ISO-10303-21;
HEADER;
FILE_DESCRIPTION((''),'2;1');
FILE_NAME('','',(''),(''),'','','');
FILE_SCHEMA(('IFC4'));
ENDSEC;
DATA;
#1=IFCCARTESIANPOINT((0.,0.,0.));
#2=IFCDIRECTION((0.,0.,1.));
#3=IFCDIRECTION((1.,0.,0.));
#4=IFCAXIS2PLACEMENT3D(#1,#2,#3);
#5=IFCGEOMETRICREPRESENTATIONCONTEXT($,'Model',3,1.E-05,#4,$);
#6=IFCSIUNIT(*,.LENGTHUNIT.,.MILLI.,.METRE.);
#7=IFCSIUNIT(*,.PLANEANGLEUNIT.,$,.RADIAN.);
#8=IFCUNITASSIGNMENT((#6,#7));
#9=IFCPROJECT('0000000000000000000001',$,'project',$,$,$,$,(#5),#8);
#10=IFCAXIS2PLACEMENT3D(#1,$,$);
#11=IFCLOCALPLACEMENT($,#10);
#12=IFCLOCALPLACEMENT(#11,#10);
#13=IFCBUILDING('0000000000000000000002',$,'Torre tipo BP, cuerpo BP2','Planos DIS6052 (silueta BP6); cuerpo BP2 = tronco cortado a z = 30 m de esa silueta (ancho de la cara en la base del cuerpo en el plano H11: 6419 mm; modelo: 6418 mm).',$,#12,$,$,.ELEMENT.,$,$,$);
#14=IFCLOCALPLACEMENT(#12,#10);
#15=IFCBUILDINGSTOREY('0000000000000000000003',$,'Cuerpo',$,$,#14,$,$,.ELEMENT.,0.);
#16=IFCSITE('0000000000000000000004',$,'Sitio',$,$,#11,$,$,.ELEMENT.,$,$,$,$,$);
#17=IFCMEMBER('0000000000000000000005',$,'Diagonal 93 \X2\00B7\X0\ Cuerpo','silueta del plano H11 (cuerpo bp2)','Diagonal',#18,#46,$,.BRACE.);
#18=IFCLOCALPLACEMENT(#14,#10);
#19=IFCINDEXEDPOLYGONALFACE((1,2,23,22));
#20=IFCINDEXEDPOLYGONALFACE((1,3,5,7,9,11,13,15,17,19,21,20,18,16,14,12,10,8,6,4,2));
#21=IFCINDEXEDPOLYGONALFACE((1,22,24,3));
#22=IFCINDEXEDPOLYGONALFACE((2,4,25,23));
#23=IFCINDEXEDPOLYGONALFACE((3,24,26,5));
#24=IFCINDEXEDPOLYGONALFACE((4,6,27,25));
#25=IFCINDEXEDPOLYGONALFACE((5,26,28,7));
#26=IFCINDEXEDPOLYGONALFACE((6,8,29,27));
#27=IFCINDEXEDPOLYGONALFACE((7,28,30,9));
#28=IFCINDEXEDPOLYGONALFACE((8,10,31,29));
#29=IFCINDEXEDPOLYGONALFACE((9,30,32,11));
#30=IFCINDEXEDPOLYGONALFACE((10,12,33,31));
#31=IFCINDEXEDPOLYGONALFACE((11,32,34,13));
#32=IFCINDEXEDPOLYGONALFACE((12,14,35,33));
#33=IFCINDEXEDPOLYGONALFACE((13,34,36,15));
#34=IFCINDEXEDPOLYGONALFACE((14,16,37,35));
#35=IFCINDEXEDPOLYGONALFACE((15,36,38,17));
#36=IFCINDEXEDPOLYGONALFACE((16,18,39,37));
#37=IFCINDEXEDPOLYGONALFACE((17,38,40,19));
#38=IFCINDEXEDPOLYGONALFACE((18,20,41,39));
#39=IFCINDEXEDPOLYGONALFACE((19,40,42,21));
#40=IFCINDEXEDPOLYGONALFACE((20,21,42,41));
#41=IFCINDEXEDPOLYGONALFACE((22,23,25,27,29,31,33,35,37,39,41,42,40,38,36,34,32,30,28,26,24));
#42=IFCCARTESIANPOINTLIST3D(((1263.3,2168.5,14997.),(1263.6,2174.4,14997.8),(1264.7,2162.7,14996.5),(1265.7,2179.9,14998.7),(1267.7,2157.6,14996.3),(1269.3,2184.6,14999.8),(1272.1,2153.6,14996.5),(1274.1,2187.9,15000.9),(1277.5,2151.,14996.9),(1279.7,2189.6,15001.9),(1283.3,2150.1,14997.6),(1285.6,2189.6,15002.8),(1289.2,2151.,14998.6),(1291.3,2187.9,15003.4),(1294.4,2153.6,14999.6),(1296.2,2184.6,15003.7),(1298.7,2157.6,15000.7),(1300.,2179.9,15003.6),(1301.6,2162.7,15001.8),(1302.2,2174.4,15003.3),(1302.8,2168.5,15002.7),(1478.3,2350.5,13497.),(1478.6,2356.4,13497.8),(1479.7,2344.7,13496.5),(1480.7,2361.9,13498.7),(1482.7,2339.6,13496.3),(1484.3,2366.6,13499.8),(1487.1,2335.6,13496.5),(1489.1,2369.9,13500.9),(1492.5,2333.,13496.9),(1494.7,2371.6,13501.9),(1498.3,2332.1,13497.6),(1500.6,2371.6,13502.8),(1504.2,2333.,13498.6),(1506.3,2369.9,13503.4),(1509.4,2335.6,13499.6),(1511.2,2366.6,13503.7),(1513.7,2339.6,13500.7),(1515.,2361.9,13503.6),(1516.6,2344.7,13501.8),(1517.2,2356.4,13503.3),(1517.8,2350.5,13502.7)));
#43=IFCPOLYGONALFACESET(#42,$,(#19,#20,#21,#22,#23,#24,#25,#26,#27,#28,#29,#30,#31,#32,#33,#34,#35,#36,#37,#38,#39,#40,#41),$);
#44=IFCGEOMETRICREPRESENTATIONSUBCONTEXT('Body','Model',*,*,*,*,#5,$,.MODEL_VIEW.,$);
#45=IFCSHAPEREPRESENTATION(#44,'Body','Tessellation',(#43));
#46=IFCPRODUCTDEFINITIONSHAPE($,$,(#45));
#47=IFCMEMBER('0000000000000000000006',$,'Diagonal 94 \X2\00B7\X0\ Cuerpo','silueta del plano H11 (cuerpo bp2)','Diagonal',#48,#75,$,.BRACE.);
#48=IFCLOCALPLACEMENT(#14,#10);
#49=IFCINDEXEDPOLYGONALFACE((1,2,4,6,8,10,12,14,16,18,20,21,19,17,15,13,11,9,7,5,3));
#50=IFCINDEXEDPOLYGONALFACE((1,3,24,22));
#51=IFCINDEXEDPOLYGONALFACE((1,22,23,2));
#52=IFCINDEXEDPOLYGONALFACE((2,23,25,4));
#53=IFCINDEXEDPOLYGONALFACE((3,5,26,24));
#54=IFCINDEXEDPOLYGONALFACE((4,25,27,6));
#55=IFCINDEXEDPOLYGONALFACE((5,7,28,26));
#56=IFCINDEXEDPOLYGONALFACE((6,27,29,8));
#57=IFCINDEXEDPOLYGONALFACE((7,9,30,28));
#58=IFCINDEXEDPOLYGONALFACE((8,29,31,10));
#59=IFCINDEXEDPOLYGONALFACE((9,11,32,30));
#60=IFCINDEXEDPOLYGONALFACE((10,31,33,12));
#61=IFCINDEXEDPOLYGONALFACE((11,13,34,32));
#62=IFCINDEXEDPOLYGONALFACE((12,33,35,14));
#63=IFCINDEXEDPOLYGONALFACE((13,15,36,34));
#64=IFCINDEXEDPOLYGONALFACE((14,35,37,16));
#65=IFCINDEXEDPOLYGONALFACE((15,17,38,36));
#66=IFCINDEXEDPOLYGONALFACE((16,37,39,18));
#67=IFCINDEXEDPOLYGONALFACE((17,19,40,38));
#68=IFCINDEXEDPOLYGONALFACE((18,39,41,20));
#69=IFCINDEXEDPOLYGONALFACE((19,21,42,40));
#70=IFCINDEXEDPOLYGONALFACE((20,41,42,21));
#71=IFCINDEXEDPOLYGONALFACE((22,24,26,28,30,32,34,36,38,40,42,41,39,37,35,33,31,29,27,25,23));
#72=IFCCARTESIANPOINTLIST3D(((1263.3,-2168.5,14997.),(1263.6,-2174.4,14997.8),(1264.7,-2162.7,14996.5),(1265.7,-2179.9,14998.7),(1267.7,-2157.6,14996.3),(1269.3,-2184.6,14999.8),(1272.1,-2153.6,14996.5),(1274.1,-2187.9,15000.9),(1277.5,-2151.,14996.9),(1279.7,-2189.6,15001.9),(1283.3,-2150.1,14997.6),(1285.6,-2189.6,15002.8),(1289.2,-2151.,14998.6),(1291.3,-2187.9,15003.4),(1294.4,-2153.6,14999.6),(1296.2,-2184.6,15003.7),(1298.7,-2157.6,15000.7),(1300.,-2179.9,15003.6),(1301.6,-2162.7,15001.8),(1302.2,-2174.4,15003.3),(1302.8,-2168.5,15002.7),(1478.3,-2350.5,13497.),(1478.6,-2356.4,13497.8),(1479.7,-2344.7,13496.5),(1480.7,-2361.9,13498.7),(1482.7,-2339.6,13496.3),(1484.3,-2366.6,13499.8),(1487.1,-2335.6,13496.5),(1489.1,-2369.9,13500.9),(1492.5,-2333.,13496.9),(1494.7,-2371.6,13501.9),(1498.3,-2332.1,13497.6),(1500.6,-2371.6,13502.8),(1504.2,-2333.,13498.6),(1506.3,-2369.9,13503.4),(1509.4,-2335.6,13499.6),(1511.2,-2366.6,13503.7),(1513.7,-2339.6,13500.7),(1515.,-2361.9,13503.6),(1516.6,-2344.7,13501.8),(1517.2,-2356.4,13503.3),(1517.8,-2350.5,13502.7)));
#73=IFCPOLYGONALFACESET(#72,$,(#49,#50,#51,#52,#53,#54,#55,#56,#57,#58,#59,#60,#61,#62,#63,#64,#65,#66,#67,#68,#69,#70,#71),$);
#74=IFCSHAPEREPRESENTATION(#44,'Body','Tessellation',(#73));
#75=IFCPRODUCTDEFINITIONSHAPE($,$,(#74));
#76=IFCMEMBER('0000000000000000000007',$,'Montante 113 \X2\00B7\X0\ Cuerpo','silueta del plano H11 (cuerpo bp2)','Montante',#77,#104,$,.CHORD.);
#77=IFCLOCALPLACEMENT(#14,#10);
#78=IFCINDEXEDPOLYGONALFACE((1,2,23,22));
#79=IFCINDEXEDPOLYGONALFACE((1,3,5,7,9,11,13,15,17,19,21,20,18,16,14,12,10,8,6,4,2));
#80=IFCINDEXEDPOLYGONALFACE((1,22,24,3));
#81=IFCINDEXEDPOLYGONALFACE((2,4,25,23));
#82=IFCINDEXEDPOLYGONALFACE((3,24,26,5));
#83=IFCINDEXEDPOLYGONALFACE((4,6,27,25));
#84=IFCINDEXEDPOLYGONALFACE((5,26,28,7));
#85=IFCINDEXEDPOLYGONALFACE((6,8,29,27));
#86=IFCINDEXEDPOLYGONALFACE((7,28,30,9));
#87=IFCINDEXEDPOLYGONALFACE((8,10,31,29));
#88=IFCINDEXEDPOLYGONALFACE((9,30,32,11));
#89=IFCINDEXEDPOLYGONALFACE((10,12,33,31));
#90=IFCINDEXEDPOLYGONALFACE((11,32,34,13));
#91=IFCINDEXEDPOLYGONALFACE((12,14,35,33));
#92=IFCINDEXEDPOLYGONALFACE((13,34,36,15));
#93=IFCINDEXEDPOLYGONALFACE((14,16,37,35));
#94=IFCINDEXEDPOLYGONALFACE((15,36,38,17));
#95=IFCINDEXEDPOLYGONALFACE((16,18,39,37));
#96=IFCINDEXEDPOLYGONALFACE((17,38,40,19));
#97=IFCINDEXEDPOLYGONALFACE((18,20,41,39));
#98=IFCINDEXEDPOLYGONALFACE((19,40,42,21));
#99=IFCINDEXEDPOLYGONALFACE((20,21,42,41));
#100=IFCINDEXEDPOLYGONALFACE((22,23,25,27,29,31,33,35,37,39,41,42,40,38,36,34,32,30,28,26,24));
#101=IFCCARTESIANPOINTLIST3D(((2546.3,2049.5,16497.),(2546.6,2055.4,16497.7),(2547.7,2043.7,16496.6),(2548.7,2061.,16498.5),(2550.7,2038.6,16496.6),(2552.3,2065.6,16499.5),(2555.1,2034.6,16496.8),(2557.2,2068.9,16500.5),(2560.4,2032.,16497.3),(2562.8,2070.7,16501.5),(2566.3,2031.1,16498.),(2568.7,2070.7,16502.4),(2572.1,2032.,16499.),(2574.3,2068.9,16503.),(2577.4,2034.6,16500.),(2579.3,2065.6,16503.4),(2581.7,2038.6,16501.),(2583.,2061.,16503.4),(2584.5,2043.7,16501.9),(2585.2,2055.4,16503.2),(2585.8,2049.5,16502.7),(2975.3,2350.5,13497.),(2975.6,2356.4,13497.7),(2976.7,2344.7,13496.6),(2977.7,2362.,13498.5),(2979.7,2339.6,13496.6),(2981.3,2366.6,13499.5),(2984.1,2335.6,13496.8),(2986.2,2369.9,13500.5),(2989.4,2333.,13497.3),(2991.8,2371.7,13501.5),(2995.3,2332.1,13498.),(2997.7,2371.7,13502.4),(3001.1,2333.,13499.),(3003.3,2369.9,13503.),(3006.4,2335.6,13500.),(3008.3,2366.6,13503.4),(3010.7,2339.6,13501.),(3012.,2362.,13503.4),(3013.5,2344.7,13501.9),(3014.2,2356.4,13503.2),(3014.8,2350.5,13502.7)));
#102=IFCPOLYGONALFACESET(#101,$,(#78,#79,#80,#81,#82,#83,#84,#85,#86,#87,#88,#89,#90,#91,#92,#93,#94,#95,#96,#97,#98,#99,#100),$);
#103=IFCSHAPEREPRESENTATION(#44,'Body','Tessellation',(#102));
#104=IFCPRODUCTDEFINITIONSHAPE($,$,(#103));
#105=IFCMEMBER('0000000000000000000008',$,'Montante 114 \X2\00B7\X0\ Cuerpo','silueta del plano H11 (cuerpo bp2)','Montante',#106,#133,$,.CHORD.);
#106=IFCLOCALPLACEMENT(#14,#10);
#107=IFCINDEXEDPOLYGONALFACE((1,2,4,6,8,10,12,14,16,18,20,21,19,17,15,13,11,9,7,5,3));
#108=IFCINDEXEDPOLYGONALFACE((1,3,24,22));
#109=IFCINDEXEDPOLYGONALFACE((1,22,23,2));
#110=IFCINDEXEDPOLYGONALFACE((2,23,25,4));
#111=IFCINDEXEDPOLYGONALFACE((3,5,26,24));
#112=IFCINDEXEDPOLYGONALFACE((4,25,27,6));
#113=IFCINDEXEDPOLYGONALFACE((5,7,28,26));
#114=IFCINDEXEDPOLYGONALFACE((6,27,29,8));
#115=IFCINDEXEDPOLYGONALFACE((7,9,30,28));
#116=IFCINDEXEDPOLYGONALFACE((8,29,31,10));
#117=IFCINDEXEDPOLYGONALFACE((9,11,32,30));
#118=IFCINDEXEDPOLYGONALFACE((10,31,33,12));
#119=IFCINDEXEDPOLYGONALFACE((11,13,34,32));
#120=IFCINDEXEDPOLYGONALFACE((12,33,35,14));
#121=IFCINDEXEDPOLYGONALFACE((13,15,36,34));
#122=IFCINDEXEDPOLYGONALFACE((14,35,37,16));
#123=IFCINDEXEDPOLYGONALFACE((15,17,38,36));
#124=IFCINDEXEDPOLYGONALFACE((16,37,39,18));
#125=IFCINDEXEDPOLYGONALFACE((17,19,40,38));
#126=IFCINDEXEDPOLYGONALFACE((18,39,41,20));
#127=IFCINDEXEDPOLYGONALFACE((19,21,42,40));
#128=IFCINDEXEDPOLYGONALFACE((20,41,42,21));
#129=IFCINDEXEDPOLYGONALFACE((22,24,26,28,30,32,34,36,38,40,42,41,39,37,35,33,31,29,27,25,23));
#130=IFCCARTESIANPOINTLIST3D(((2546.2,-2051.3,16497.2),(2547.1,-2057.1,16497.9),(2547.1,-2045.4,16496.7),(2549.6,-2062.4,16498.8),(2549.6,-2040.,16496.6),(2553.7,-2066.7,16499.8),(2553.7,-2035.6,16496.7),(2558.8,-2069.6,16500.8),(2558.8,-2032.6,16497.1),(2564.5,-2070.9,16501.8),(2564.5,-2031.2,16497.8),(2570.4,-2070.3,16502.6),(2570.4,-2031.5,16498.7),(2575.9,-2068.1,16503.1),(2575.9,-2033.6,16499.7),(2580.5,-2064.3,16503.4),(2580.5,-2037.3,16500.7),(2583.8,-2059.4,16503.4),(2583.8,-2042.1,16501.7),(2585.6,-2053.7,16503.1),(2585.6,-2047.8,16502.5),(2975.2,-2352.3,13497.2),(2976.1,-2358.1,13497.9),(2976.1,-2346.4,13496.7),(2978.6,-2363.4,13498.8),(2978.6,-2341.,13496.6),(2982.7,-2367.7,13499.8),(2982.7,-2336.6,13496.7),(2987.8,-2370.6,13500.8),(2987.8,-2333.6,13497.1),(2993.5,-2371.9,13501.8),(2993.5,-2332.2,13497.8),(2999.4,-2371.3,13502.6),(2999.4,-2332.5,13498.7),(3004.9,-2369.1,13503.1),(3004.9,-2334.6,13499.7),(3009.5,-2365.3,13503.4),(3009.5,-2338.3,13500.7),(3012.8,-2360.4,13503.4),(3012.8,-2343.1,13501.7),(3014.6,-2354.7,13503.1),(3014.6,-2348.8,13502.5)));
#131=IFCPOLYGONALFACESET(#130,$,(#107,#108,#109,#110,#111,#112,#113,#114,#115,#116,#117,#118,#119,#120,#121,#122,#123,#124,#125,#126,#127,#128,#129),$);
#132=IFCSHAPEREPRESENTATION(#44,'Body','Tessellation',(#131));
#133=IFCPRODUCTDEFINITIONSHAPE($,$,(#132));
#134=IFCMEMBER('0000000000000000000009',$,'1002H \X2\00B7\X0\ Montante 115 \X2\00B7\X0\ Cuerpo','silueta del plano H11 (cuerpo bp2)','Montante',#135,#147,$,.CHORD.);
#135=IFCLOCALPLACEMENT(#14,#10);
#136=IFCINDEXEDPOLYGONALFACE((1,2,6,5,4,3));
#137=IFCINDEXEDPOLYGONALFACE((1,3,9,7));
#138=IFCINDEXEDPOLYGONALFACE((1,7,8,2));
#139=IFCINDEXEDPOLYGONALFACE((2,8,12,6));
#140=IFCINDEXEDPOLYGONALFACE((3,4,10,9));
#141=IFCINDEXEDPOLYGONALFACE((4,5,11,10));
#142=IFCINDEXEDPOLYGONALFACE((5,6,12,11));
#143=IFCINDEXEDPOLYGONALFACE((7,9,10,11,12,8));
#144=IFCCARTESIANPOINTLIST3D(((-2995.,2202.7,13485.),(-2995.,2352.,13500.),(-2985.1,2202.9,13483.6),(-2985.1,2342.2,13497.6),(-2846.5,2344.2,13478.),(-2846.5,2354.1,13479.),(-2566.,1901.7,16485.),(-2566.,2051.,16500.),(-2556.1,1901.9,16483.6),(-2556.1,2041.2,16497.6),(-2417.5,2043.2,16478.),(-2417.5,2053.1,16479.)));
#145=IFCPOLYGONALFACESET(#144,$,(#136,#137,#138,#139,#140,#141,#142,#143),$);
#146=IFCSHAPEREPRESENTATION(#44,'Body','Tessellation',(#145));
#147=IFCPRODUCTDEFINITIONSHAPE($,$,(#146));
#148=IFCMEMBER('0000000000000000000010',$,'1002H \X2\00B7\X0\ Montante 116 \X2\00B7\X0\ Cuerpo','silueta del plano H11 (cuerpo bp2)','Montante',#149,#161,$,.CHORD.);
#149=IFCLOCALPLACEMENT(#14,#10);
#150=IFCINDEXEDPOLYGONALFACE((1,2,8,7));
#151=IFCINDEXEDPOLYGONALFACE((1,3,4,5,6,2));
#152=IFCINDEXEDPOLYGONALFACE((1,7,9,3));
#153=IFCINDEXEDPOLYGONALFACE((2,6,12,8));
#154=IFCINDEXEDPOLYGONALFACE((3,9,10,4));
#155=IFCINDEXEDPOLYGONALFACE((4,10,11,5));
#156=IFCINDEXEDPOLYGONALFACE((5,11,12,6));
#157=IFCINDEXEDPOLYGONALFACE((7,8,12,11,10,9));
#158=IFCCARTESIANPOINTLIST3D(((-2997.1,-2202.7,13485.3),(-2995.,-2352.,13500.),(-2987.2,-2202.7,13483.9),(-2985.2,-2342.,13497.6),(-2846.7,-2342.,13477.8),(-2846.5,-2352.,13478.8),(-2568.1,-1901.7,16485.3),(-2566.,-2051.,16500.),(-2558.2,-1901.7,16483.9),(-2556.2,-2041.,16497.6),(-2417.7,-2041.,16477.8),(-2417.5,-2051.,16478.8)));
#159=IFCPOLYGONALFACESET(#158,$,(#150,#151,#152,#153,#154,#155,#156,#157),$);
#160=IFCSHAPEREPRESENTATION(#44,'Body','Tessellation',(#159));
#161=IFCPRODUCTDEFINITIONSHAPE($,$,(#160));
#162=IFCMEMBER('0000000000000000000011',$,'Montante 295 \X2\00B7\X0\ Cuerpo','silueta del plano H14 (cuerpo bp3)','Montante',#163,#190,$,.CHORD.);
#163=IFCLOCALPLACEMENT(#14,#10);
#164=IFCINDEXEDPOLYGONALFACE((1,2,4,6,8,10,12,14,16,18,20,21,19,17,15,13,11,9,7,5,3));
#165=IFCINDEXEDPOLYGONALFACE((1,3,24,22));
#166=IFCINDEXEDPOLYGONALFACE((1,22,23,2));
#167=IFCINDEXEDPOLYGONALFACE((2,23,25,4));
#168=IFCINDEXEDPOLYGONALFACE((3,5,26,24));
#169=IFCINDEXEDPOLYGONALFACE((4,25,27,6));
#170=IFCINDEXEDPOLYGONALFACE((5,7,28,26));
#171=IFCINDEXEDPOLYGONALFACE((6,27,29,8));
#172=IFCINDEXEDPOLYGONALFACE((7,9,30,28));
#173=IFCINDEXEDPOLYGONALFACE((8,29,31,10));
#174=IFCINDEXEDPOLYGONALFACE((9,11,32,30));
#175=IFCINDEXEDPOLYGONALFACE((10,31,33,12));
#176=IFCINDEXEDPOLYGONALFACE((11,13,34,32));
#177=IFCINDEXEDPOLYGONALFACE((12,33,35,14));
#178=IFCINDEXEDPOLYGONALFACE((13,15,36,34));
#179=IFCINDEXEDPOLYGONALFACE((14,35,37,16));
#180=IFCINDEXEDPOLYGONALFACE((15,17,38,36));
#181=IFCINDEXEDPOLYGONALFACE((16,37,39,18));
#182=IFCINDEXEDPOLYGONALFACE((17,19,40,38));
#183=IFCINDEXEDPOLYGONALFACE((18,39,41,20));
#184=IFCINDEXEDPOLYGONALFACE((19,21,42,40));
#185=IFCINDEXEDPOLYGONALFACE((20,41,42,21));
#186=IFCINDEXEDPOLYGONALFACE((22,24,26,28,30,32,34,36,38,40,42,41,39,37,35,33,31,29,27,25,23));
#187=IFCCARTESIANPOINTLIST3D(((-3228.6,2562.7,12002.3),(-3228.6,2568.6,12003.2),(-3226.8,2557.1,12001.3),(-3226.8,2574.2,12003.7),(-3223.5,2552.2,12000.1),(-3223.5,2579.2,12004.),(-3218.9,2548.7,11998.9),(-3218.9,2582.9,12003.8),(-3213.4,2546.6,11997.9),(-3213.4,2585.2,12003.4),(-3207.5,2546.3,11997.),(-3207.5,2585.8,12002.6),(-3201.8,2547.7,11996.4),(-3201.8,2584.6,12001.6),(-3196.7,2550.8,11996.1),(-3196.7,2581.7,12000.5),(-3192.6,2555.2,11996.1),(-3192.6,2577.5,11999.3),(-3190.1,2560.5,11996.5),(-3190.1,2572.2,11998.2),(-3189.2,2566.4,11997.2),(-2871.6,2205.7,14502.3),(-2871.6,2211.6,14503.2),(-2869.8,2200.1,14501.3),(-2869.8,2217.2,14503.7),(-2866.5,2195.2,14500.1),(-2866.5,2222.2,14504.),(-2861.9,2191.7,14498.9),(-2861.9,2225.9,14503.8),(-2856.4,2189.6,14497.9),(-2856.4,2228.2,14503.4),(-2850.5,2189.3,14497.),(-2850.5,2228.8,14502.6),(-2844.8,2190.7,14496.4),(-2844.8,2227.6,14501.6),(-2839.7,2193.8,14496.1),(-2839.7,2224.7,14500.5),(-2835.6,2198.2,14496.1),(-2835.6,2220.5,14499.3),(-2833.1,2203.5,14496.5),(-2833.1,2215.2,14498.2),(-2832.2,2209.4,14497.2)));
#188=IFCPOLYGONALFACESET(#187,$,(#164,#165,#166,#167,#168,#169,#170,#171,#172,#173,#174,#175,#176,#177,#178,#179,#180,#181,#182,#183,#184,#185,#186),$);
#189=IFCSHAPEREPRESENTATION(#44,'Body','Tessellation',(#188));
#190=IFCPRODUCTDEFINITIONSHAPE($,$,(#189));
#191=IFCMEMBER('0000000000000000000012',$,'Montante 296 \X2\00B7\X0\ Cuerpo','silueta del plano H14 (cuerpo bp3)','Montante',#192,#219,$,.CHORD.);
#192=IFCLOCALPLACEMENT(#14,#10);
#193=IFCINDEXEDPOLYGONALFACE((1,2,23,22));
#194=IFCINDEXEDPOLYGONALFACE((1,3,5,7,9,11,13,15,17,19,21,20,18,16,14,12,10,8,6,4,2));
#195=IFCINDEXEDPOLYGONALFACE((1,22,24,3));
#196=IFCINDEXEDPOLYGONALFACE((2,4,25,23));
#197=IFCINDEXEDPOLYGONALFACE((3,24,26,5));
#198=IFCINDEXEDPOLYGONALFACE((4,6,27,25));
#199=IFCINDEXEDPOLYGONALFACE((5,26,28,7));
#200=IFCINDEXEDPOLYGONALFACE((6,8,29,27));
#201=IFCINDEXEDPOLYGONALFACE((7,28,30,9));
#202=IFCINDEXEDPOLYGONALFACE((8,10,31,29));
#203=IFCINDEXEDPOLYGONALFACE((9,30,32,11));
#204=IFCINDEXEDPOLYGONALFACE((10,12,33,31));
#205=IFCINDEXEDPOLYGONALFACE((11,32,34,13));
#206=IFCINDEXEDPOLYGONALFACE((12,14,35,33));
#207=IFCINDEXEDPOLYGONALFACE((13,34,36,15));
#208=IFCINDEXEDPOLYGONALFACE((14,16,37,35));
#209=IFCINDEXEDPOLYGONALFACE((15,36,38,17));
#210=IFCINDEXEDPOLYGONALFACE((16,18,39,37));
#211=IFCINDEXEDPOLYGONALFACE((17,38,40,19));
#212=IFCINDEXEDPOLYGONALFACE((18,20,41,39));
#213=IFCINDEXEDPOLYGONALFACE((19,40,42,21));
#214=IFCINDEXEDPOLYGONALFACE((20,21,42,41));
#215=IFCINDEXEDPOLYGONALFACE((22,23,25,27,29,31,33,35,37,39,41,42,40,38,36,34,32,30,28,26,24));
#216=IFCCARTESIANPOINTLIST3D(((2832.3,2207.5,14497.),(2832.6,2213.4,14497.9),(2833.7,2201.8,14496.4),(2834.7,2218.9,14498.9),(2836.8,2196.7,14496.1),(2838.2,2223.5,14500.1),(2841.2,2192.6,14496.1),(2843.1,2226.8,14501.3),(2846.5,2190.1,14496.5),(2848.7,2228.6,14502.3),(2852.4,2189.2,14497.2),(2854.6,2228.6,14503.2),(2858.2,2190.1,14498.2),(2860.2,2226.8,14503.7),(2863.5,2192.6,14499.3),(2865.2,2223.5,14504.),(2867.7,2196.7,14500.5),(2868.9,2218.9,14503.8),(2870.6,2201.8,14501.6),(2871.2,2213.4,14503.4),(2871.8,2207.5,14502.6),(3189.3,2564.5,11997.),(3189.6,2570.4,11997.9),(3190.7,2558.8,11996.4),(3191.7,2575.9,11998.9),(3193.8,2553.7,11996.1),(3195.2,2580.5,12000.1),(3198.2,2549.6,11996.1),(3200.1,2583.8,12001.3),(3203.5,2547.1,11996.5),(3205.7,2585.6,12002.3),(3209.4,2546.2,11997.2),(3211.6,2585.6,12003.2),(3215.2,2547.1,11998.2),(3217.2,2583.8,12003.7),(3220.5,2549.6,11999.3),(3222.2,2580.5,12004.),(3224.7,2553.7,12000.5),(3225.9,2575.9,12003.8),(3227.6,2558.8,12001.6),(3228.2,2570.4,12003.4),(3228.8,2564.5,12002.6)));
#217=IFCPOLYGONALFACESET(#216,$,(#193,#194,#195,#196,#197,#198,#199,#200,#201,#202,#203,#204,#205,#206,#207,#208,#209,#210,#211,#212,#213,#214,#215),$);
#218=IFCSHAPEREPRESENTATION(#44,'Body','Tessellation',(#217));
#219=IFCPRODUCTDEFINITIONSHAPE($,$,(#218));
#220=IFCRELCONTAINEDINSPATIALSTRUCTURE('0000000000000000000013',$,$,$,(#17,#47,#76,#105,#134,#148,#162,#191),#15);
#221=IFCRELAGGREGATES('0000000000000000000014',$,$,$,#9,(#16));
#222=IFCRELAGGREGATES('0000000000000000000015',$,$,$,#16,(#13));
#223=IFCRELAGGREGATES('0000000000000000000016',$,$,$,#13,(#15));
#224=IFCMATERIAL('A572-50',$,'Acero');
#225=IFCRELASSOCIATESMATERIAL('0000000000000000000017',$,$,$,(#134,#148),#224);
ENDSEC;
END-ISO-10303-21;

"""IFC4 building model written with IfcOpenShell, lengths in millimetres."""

from ifc_helpers import new_model, si_unit, frame, frame_2d, origin, origin_with_axes, place, context, subcontext, project, spatial, circle, l_section, extrude, material, element, save


model = new_model("IFC4")

# Units and contexts
model_context = context("Model", 3, precision=1e-05, world=origin_with_axes())
body_context = subcontext(model_context, "Body", "Model", "MODEL_VIEW")
ifc_project = project(units=[si_unit("LENGTHUNIT", "METRE", prefix="MILLI"), si_unit("PLANEANGLEUNIT", "RADIAN")], contexts=[model_context])

# Site, building, storey
site_placement = place(None, origin())
site = spatial("IfcSite", under=ifc_project, at=site_placement, Name="Sitio", CompositionType="ELEMENT")
building_placement = place(site_placement, origin())
building = spatial("IfcBuilding", under=site, at=building_placement, Name="Torre tipo BP, cuerpo BP2", Description="Planos DIS6052 (silueta BP6); cuerpo BP2 = tronco cortado a z = 30 m de esa silueta (ancho de la cara en la base del cuerpo en el plano H11: 6419 mm; modelo: 6418 mm).", CompositionType="ELEMENT")
storey_placement = place(building_placement, origin())
storey = spatial("IfcBuildingStorey", under=building, at=storey_placement, Name="Cuerpo", CompositionType="ELEMENT", Elevation=0.0)

# Members
for number, where, z_axis, x_axis, name in (
    (1, (1283.0, 2170.0, 15000.0), (0.140871, 0.119249, -0.98282), (0.016919, -0.992864, -0.118042), "Diagonal 93 · Cuerpo"),
    (2, (1283.0, -2170.0, 15000.0), (0.140871, -0.119249, -0.98282), (0.016919, 0.992864, -0.118042), "Diagonal 94 · Cuerpo"),
):
    element("IfcMember", number, at=place(storey_placement, frame(where, z_axis=z_axis, x_axis=x_axis)), inside=storey, Name=name, Description="silueta del plano H11 (cuerpo bp2)", ObjectType="Diagonal", PredefinedType="BRACE", context=body_context, shape_type="SweptSolid", body=[
        extrude(circle(Radius=20.0), None, (0.0, 0.0, 1.0), 1526.2),
    ])
for number, where, z_axis, x_axis, name in (
    (3, (2566.0, 2051.0, 16500.0), (0.140867, 0.098837, -0.985083), (0.013991, -0.995104, -0.097841), "Montante 113 · Cuerpo"),
    (4, (2566.0, -2051.0, 16500.0), (0.140867, -0.098837, -0.985083), (-0.990029, -0.014063, -0.140163), "Montante 114 · Cuerpo"),
):
    element("IfcMember", number, at=place(storey_placement, frame(where, z_axis=z_axis, x_axis=x_axis)), inside=storey, Name=name, Description="silueta del plano H11 (cuerpo bp2)", ObjectType="Montante", PredefinedType="CHORD", context=body_context, shape_type="SweptSolid", body=[
        extrude(circle(Radius=20.0), None, (0.0, 0.0, 1.0), 3045.4),
    ])
ifc_material = material(Name="A572-50", Category="Acero")
for number, where, z_axis, x_axis, name in (
    (5, (-2566.0, 2051.0, 16500.0), (-0.140867, 0.098837, -0.985083), (0.990029, 0.014063, -0.140163), "1002H · Montante 115 · Cuerpo"),
    (6, (-2566.0, -2051.0, 16500.0), (-0.140867, -0.098837, -0.985083), (-0.013991, 0.995104, -0.097841), "1002H · Montante 116 · Cuerpo"),
):
    element("IfcMember", number, at=place(storey_placement, frame(where, z_axis=z_axis, x_axis=x_axis)), inside=storey, material=ifc_material, Name=name, Description="silueta del plano H11 (cuerpo bp2)", ObjectType="Montante", PredefinedType="CHORD", context=body_context, shape_type="SweptSolid", body=[
        extrude(l_section(Depth=150.0, Width=150.0, Thickness=10.0, at=frame_2d((75.0, 75.0))), None, (0.0, 0.0, 1.0), 3045.4),
    ])
for number, where, z_axis, x_axis, name in (
    (7, (-2852.0, 2209.0, 14500.0), (-0.139974, 0.139974, -0.980211), (0.990155, 0.019788, -0.138568), "Montante 295 · Cuerpo"),
    (8, (2852.0, 2209.0, 14500.0), (0.139974, 0.139974, -0.980211), (0.019788, -0.990155, -0.138568), "Montante 296 · Cuerpo"),
):
    element("IfcMember", number, at=place(storey_placement, frame(where, z_axis=z_axis, x_axis=x_axis)), inside=storey, Name=name, Description="silueta del plano H14 (cuerpo bp3)", ObjectType="Montante", PredefinedType="CHORD", context=body_context, shape_type="SweptSolid", body=[
        extrude(circle(Radius=20.0), None, (0.0, 0.0, 1.0), 2550.5),
    ])

save(model, "model.ifc")
